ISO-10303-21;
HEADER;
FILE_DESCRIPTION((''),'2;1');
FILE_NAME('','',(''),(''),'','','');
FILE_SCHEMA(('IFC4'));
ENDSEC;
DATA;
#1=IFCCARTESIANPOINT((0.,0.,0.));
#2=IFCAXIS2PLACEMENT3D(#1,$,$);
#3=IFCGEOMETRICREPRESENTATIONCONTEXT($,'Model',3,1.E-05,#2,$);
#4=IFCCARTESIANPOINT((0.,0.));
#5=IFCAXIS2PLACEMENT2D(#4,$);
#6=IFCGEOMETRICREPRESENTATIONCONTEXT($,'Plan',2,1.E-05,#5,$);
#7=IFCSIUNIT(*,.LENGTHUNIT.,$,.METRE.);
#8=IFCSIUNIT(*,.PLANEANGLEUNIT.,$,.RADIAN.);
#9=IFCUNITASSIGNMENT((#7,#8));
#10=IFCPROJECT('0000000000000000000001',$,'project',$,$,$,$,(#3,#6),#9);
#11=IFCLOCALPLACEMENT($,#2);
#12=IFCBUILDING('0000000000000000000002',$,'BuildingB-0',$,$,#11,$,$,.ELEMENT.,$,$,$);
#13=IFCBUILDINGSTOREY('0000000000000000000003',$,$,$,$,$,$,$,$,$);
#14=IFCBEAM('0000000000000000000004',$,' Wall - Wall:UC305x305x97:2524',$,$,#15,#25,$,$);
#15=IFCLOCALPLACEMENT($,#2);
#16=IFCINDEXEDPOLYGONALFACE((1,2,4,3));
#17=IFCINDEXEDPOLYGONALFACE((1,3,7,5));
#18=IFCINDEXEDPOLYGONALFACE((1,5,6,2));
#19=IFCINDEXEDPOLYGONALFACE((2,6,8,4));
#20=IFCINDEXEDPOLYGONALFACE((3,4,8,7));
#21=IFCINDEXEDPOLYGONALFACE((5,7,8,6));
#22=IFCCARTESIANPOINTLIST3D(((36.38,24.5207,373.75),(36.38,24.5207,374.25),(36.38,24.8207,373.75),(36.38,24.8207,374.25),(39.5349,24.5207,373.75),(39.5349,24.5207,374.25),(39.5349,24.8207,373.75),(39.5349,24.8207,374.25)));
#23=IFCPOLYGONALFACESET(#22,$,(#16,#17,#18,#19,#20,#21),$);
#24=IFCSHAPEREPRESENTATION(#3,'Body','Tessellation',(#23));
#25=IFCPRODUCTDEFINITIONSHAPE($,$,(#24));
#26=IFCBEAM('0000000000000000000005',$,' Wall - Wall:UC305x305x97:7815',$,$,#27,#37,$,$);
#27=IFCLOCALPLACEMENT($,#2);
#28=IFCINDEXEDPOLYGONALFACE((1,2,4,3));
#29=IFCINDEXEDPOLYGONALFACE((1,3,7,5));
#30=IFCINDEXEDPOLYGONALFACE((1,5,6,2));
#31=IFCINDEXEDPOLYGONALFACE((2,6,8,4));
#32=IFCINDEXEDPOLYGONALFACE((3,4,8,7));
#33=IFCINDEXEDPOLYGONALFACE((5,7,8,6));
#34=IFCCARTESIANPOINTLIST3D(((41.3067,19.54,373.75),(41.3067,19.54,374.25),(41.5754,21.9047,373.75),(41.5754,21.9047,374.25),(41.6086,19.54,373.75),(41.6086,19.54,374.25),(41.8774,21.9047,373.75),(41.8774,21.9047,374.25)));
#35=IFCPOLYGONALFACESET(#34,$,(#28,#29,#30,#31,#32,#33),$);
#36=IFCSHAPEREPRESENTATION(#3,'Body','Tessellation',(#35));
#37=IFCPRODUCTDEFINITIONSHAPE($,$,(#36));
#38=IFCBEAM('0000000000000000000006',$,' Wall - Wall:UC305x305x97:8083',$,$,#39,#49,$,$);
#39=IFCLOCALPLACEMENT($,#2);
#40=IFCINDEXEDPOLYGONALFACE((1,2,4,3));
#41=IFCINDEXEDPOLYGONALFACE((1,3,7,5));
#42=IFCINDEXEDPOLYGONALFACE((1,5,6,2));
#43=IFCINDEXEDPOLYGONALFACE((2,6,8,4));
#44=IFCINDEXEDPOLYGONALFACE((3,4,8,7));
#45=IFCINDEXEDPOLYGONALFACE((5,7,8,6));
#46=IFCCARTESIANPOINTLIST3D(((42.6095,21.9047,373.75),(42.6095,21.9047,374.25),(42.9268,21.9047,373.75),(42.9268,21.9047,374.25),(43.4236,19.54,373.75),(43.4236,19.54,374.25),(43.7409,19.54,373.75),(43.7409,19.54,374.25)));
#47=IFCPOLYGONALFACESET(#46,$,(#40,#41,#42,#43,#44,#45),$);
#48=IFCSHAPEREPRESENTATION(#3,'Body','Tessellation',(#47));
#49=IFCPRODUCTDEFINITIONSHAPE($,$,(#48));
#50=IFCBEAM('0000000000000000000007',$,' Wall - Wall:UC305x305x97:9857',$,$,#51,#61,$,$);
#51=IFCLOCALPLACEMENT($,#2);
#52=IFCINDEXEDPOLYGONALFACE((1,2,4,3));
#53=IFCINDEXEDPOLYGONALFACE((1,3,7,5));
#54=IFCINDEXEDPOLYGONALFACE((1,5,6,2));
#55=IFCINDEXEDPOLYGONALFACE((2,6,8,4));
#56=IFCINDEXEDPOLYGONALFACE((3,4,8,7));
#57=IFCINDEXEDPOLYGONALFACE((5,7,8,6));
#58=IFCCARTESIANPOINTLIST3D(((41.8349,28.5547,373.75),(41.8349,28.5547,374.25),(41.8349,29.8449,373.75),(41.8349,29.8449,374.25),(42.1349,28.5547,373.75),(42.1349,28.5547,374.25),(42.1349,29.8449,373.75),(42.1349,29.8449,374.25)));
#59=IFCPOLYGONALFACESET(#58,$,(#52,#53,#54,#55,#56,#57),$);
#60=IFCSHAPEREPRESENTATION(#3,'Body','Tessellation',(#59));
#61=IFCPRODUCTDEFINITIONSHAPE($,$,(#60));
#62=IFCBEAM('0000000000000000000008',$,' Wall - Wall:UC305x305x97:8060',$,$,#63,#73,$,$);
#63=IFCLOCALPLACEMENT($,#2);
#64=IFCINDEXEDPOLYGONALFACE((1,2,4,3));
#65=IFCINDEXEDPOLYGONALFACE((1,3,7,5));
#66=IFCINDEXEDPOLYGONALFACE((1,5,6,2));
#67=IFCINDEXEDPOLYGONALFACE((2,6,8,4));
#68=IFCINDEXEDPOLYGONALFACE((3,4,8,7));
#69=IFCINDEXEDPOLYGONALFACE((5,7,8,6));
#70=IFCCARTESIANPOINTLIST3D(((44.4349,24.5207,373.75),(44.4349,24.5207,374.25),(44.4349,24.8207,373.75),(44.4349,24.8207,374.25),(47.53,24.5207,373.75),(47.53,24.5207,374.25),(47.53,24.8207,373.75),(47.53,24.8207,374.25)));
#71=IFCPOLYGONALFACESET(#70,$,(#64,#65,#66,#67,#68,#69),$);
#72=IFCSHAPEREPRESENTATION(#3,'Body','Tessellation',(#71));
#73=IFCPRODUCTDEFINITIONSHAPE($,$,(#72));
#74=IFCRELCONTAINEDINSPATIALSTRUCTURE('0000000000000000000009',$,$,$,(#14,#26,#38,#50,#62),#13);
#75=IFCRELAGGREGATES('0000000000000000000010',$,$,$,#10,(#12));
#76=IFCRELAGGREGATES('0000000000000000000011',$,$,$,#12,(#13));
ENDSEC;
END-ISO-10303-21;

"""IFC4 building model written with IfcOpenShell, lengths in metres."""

from ifc_helpers import new_model, si_unit, origin, origin_2d, place, context, project, spatial, polyline, outline, extrude, element, save


model = new_model("IFC4")

# Units and contexts
model_context = context("Model", 3, precision=1e-05, world=origin())
plan_context = context("Plan", 2, precision=1e-05, world=origin_2d())
ifc_project = project(units=[si_unit("LENGTHUNIT", "METRE"), si_unit("PLANEANGLEUNIT", "RADIAN")], contexts=[model_context, plan_context])

# Building, storey
building_placement = place(None, origin())
building = spatial("IfcBuilding", under=ifc_project, at=building_placement, Name="BuildingB-0", CompositionType="ELEMENT")
storey = spatial("IfcBuildingStorey", under=building)

# Beams
element("IfcBeam", 1, inside=storey, Name=" Wall - Wall:UC305x305x97:2524", context=model_context, shape_type="SweptSolid", body=[
    extrude(outline(polyline([(36.38, 24.5207, 373.75), (36.38, 24.8207, 373.75), (39.5349, 24.8207, 373.75), (39.5349, 24.5207, 373.75), (36.38, 24.5207, 373.75)])), None, (0.0, 0.0, 1.0), 0.5),
])
element("IfcBeam", 2, inside=storey, Name=" Wall - Wall:UC305x305x97:7815", context=model_context, shape_type="SweptSolid", body=[
    extrude(outline(polyline([(41.3067, 19.54, 373.75), (41.6086, 19.54, 373.75), (41.8774, 21.9047, 373.75), (41.5754, 21.9047, 373.75), (41.3067, 19.54, 373.75)])), None, (0.0, 0.0, 1.0), 0.5),
])
element("IfcBeam", 3, inside=storey, Name=" Wall - Wall:UC305x305x97:8083", context=model_context, shape_type="SweptSolid", body=[
    extrude(outline(polyline([(43.4236, 19.54, 373.75), (43.7409, 19.54, 373.75), (42.9268, 21.9047, 373.75), (42.6095, 21.9047, 373.75), (43.4236, 19.54, 373.75)])), None, (0.0, 0.0, 1.0), 0.5),
])
element("IfcBeam", 4, inside=storey, Name=" Wall - Wall:UC305x305x97:9857", context=model_context, shape_type="SweptSolid", body=[
    extrude(outline(polyline([(41.8349, 28.5547, 373.75), (42.1349, 28.5547, 373.75), (42.1349, 29.8449, 373.75), (41.8349, 29.8449, 373.75), (41.8349, 28.5547, 373.75)])), None, (0.0, 0.0, 1.0), 0.5),
])
element("IfcBeam", 5, inside=storey, Name=" Wall - Wall:UC305x305x97:8060", context=model_context, shape_type="SweptSolid", body=[
    extrude(outline(polyline([(44.4349, 24.5207, 373.75), (44.4349, 24.8207, 373.75), (47.53, 24.8207, 373.75), (47.53, 24.5207, 373.75), (44.4349, 24.5207, 373.75)])), None, (0.0, 0.0, 1.0), 0.5),
])

save(model, "model.ifc")
